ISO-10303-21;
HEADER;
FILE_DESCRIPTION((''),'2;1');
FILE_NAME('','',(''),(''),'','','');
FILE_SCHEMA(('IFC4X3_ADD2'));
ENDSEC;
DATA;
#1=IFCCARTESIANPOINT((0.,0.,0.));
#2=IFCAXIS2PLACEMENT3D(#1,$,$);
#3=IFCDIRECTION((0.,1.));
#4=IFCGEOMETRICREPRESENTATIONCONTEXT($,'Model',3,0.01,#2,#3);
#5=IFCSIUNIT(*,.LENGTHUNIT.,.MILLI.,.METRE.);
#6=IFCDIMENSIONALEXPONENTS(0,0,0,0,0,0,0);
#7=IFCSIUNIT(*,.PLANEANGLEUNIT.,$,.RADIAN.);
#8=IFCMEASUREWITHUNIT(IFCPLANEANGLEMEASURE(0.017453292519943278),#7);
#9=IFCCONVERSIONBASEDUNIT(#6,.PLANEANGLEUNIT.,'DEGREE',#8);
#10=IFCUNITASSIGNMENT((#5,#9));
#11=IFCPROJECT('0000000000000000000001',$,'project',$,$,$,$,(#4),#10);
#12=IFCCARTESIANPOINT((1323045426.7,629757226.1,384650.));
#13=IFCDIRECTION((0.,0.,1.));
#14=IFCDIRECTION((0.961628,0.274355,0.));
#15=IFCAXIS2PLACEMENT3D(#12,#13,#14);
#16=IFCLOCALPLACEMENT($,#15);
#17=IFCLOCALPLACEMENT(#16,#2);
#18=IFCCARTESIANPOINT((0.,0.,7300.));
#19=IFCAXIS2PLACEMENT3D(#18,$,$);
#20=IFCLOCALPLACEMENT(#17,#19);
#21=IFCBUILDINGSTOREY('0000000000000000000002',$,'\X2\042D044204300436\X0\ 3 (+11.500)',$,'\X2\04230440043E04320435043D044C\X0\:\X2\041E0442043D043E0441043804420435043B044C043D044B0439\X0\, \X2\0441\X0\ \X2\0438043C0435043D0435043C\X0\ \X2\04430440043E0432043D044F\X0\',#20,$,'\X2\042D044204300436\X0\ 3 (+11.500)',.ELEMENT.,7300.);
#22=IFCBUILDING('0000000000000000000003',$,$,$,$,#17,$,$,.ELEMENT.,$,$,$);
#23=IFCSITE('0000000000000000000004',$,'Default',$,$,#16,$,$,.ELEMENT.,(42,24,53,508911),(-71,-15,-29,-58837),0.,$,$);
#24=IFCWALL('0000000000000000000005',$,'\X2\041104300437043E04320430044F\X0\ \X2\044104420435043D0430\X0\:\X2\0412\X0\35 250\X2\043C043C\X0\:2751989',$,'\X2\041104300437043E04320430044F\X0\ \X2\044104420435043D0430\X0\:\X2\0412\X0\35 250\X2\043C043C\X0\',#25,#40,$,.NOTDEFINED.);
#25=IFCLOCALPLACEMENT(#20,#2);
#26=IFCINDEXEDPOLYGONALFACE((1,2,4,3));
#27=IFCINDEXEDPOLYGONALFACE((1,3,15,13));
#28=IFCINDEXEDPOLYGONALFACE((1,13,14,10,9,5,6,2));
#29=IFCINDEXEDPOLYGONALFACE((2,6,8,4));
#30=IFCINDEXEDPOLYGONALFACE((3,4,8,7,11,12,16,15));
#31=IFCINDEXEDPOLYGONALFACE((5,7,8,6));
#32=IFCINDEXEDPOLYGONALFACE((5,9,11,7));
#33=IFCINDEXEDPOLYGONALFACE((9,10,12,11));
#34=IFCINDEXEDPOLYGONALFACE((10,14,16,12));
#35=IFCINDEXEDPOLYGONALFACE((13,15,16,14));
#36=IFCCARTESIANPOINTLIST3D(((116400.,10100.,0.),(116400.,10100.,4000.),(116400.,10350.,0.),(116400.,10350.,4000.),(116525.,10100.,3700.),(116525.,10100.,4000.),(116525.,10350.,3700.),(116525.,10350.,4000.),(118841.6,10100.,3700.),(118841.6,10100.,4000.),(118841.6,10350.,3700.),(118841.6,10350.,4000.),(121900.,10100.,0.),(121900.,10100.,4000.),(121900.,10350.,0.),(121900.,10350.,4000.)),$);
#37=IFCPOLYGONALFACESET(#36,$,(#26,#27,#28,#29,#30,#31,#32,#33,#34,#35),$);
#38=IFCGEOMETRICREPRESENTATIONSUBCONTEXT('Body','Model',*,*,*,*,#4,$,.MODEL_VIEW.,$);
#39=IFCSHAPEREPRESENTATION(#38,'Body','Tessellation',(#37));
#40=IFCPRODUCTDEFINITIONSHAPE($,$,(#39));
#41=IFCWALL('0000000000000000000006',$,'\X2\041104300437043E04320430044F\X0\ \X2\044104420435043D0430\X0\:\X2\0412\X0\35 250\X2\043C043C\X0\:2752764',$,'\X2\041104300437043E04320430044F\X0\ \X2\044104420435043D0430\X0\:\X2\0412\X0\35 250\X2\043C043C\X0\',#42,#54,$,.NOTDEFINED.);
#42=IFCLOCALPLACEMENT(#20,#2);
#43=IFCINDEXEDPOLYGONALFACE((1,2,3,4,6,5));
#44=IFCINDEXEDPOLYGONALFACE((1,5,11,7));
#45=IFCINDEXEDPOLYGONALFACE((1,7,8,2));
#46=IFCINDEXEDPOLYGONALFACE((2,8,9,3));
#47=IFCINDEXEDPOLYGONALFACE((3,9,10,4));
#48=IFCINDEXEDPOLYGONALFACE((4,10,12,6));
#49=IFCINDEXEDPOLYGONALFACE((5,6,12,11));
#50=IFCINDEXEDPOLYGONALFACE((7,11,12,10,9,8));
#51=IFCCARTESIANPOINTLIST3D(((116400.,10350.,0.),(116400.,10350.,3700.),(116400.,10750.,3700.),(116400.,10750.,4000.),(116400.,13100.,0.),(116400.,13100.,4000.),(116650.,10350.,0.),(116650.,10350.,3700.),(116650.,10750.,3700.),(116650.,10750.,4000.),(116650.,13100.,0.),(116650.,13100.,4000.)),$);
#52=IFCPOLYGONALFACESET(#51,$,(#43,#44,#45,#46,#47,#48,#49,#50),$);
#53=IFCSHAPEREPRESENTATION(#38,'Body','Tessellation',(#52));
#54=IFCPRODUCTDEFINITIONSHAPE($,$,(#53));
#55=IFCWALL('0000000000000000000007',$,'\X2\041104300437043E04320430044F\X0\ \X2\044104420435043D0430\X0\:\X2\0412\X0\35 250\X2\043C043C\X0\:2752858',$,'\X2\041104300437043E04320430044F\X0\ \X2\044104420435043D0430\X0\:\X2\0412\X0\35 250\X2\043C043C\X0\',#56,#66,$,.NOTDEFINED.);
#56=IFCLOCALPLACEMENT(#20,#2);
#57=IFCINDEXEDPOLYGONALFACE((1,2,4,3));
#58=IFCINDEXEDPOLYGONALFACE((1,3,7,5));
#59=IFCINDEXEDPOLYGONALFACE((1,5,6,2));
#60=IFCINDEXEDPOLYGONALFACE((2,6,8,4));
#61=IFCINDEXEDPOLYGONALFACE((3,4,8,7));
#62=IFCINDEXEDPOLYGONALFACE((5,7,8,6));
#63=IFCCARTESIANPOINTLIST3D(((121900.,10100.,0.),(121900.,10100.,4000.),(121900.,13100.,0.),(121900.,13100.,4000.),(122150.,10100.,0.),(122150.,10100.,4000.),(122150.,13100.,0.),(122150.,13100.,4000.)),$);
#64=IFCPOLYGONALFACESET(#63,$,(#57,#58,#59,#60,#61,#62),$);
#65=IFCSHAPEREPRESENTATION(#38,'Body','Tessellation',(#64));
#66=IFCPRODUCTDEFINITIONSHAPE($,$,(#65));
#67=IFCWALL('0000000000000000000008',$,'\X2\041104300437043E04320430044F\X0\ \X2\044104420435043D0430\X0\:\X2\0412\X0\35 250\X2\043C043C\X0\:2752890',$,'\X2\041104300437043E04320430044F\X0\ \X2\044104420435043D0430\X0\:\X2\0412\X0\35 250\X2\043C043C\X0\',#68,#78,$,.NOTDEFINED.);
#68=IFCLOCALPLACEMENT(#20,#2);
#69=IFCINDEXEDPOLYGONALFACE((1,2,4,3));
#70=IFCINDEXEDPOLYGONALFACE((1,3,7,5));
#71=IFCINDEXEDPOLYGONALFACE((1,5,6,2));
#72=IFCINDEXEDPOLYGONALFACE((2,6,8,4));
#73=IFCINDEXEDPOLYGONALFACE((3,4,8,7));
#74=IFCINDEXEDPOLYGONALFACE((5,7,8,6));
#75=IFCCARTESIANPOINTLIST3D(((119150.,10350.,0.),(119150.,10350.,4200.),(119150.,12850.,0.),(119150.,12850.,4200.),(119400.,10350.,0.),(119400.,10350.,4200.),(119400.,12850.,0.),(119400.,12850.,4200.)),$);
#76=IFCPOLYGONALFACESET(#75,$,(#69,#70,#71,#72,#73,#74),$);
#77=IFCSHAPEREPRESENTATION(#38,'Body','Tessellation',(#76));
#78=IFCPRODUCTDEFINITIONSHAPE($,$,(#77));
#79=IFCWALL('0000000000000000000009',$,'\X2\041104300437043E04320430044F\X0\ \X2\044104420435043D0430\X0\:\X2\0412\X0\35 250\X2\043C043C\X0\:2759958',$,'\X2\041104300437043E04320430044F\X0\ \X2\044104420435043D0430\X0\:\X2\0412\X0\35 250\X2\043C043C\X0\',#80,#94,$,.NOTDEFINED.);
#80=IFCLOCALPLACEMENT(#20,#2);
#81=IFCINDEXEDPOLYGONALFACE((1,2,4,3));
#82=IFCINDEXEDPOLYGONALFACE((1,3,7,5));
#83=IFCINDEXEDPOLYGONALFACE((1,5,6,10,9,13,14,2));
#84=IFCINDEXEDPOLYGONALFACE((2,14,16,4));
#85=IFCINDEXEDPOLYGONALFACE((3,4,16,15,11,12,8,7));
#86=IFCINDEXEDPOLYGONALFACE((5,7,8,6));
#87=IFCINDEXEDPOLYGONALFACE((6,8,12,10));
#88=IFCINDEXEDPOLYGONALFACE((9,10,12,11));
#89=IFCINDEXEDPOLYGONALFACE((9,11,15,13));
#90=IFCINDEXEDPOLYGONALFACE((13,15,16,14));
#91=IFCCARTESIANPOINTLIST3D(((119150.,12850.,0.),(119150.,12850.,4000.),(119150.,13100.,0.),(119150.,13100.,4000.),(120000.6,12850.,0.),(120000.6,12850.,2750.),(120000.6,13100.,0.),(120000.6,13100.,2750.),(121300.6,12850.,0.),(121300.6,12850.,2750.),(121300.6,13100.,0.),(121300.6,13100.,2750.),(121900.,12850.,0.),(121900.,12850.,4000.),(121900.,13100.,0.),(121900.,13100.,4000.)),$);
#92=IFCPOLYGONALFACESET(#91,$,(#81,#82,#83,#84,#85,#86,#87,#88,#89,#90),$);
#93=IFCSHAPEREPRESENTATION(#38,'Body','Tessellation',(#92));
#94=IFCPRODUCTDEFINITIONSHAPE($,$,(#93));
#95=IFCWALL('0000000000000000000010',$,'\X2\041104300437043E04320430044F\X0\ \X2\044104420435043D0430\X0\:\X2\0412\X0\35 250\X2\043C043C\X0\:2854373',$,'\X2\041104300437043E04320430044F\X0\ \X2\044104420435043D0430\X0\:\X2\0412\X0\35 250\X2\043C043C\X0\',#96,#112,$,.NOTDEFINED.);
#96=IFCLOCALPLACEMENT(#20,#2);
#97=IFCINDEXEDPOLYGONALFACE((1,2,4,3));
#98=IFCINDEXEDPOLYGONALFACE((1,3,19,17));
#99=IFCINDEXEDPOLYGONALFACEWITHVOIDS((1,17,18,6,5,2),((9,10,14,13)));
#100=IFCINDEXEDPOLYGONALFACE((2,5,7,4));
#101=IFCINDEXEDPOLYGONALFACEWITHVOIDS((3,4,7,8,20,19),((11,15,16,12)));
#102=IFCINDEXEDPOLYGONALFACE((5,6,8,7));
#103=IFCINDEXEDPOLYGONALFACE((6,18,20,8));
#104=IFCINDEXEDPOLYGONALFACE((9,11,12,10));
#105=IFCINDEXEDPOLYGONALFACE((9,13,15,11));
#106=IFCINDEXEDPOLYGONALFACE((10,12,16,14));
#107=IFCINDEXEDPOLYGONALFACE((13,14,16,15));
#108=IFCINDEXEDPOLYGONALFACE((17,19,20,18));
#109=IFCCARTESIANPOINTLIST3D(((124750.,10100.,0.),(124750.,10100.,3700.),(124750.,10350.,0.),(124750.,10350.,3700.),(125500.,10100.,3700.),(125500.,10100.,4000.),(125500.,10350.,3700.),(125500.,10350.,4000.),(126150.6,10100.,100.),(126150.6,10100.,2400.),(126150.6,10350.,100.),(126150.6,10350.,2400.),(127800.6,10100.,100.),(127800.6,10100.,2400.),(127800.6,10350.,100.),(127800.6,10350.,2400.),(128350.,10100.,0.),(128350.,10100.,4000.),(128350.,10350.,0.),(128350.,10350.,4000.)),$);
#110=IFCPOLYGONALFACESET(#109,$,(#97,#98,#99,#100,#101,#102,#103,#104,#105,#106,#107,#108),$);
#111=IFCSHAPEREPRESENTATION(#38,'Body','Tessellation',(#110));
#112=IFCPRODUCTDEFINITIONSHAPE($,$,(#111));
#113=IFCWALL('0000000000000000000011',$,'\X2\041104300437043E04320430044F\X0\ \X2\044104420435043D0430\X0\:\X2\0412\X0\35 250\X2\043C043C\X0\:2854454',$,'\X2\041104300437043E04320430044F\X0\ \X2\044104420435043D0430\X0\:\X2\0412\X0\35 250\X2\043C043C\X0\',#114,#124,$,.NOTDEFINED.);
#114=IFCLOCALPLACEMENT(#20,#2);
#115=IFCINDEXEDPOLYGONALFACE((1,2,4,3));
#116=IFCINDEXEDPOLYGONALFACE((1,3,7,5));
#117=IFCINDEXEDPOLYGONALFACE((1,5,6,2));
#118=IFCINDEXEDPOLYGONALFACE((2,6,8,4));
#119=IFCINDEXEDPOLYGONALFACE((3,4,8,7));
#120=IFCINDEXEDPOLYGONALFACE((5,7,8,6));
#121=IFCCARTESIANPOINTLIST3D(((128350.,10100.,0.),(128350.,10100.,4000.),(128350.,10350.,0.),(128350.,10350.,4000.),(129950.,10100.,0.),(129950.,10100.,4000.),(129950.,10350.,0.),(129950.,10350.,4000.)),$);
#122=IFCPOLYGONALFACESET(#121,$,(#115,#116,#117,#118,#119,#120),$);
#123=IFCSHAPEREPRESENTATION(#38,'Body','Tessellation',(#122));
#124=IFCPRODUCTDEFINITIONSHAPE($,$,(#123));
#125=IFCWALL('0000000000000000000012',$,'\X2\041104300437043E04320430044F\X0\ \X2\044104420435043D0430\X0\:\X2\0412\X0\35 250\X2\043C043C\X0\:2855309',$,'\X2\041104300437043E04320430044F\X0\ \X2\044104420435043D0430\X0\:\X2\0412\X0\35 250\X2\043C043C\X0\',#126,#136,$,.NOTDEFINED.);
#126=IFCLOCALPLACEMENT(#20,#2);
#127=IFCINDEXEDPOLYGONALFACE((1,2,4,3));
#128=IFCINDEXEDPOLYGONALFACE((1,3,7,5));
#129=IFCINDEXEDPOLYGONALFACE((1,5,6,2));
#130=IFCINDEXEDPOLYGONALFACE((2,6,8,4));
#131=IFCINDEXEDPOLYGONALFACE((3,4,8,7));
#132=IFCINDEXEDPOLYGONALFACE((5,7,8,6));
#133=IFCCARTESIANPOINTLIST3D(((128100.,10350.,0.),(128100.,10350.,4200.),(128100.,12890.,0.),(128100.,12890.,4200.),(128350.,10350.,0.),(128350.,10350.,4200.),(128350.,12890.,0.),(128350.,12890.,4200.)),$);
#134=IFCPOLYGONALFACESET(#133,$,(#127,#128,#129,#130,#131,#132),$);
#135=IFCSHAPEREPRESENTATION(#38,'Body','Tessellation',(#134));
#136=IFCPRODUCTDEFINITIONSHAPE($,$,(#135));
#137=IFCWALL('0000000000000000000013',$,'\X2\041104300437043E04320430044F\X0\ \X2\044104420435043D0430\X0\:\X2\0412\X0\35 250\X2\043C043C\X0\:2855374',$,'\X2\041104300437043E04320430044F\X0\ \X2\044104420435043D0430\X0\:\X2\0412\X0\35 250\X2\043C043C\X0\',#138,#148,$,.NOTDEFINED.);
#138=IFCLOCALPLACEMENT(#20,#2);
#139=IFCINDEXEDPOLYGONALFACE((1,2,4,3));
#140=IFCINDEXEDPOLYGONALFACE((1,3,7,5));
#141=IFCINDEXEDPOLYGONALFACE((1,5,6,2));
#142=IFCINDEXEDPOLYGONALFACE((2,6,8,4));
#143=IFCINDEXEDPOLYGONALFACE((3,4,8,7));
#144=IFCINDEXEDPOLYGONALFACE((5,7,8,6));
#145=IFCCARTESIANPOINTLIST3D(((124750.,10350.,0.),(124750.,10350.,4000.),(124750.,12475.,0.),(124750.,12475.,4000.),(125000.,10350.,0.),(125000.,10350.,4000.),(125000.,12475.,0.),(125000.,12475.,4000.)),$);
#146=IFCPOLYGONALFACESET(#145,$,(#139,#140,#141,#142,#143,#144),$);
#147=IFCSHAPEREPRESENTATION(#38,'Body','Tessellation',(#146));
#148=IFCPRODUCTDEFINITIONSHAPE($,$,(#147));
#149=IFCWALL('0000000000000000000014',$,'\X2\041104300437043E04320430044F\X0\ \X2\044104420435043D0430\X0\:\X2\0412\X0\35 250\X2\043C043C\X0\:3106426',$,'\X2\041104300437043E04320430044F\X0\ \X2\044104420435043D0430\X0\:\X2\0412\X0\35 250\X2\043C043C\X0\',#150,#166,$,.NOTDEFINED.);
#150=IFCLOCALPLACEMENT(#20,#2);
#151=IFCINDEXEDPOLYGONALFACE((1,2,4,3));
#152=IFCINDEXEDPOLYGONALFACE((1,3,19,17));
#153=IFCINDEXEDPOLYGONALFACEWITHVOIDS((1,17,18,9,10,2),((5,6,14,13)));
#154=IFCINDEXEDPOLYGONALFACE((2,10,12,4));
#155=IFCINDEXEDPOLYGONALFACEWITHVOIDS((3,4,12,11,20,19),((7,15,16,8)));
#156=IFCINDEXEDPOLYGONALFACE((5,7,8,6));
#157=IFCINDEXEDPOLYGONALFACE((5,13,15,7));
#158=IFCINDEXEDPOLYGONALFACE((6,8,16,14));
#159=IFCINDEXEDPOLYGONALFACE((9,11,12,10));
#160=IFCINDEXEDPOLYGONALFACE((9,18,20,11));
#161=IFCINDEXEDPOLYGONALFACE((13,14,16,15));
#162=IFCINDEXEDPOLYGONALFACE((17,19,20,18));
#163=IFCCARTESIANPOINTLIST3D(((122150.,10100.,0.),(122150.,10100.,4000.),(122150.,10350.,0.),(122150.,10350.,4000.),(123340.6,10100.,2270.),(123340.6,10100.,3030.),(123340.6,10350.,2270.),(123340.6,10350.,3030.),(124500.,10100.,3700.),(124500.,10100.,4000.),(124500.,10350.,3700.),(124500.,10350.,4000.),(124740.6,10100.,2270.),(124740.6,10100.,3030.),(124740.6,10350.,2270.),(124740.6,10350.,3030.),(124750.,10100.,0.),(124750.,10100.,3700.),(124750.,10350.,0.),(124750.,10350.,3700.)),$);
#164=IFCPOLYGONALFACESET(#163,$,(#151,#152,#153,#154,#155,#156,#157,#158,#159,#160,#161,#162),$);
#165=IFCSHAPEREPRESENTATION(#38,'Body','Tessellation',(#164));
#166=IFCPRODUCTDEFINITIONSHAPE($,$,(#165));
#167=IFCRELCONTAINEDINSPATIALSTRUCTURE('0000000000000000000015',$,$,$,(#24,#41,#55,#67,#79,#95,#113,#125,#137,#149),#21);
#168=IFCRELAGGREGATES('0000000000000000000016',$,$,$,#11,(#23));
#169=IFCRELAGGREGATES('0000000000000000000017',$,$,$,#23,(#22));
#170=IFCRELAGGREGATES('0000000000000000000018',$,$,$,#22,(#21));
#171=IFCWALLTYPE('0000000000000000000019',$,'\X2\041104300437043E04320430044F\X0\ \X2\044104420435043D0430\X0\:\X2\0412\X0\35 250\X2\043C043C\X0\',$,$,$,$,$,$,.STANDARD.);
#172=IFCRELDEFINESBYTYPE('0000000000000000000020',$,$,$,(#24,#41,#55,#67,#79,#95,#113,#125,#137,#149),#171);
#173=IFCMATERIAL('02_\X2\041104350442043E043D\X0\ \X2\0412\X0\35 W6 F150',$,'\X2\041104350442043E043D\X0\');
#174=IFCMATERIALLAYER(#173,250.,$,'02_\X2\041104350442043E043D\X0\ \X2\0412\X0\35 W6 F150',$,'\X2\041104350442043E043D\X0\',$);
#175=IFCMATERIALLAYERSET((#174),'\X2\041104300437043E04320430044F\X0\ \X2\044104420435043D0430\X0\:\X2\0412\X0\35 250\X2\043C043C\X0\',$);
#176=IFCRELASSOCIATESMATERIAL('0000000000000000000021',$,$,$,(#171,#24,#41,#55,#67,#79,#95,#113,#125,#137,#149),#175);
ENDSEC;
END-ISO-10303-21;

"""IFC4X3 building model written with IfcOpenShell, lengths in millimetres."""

from ifc_helpers import new_model, entity, si_unit, converted_unit, direction, frame, frame_2d, origin, origin_2d_with_axis, place, context, subcontext, project, spatial, rectangle, extrude, material, layer, layer_set, type_object, element, save


model = new_model("IFC4X3")

# Units and contexts
model_context = context("Model", 3, precision=0.01, world=origin(), true_north=direction((0.0, 1.0)))
body_context = subcontext(model_context, "Body", "Model", "MODEL_VIEW")
ifc_project = project(units=[si_unit("LENGTHUNIT", "METRE", prefix="MILLI"), converted_unit("PLANEANGLEUNIT", "DEGREE", entity("IfcPlaneAngleMeasure", 0.017453292519943278), si_unit("PLANEANGLEUNIT", "RADIAN"), dimensions=[0, 0, 0, 0, 0, 0, 0])], contexts=[model_context])

# Site, building, storey
site_placement = place(None, frame((1323045426.7, 629757226.1, 384650.0), z_axis=(0.0, 0.0, 1.0), x_axis=(0.961628, 0.274355, 0.0)))
site = spatial("IfcSite", under=ifc_project, at=site_placement, Name="Default", CompositionType="ELEMENT", RefLatitude=(42, 24, 53, 508911), RefLongitude=(-71, -15, -29, -58837), RefElevation=0.0)
building_placement = place(site_placement, origin())
building = spatial("IfcBuilding", under=site, at=building_placement, CompositionType="ELEMENT")
storey_placement = place(building_placement, frame((0.0, 0.0, 7300.0)))
storey = spatial("IfcBuildingStorey", under=building, at=storey_placement, Name="Этаж 3 (+11.500)", ObjectType="Уровень:Относительный, с именем уровня", LongName="Этаж 3 (+11.500)", CompositionType="ELEMENT", Elevation=7300.0)

# Wall, opening
ifc_material = material(Name="02_Бетон В35 W6 F150", Category="Бетон")
ifc_layer_1 = layer(ifc_material, 250.0, Name="02_Бетон В35 W6 F150", Category="Бетон")
ifc_layer_set_1 = layer_set([ifc_layer_1], Name="Базовая стена:В35 250мм")
wall_type_1 = type_object("IfcWallType", Name="Базовая стена:В35 250мм", PredefinedType="STANDARD", material=ifc_layer_set_1)
wall_1_placement = place(storey_placement, frame((116400.0, 10225.0, 0.0)))
wall_1 = element("IfcWall", 1, at=wall_1_placement, inside=storey, type_object=wall_type_1, material=ifc_layer_set_1, Name="Базовая стена:В35 250мм:2751989", ObjectType="Базовая стена:В35 250мм", PredefinedType="NOTDEFINED", context=body_context, shape_type="SweptSolid", body=[
    extrude(rectangle(XDim=5500.0, YDim=250.0, at=frame_2d((2750.0, 0.0), x_axis=(-1.0, 0.0))), origin(), (0.0, 0.0, 1.0), 4000.0),
])
opening_1_placement = place(wall_1_placement, origin())
element("IfcOpeningElement", 2, at=opening_1_placement, cuts=wall_1, PredefinedType="OPENING", context=body_context, shape_type="SweptSolid", body=[
    extrude(rectangle(XDim=300.0, YDim=2316.6, at=frame_2d((0.0, 0.0), x_axis=(0.0, 1.0))), frame((1283.3, 125.0, 3850.0), z_axis=(0.0, -1.0, 0.0), x_axis=(-1.0, 0.0, 0.0)), (0.0, 0.0, 1.0), 250.0),
])

# Wall, opening
wall_2_placement = place(storey_placement, frame((116525.0, 10350.0, 0.0), z_axis=(0.0, 0.0, 1.0), x_axis=(0.0, 1.0, 0.0)))
wall_2 = element("IfcWall", 3, at=wall_2_placement, inside=storey, type_object=wall_type_1, material=ifc_layer_set_1, Name="Базовая стена:В35 250мм:2752764", ObjectType="Базовая стена:В35 250мм", PredefinedType="NOTDEFINED", context=body_context, shape_type="SweptSolid", body=[
    extrude(rectangle(XDim=2750.0, YDim=250.0, at=frame_2d((1375.0, 0.0), x_axis=(-1.0, 0.0))), origin(), (0.0, 0.0, 1.0), 4000.0),
])
opening_2_placement = place(wall_2_placement, origin())
element("IfcOpeningElement", 4, at=opening_2_placement, cuts=wall_2, PredefinedType="OPENING", context=body_context, shape_type="SweptSolid", body=[
    extrude(rectangle(XDim=300.0, YDim=525.0, at=frame_2d((0.0, 0.0), x_axis=(0.0, 1.0))), frame((137.5, 125.0, 3850.0), z_axis=(0.0, -1.0, 0.0), x_axis=(-1.0, 0.0, 0.0)), (0.0, 0.0, 1.0), 250.0),
])

# Walls
wall_3_placement = place(storey_placement, frame((122025.0, 13100.0, 0.0), z_axis=(0.0, 0.0, 1.0), x_axis=(0.0, -1.0, 0.0)))
element("IfcWall", 5, at=wall_3_placement, inside=storey, type_object=wall_type_1, material=ifc_layer_set_1, Name="Базовая стена:В35 250мм:2752858", ObjectType="Базовая стена:В35 250мм", PredefinedType="NOTDEFINED", context=body_context, shape_type="SweptSolid", body=[
    extrude(rectangle(XDim=3000.0, YDim=250.0, at=frame_2d((1500.0, 0.0), x_axis=(-1.0, 0.0))), origin(), (0.0, 0.0, 1.0), 4000.0),
])
wall_4_placement = place(storey_placement, frame((119275.0, 12850.0, 0.0), z_axis=(0.0, 0.0, 1.0), x_axis=(0.0, -1.0, 0.0)))
element("IfcWall", 6, at=wall_4_placement, inside=storey, type_object=wall_type_1, material=ifc_layer_set_1, Name="Базовая стена:В35 250мм:2752890", ObjectType="Базовая стена:В35 250мм", PredefinedType="NOTDEFINED", context=body_context, shape_type="SweptSolid", body=[
    extrude(rectangle(XDim=2500.0, YDim=250.0, at=frame_2d((1250.0, 0.0), x_axis=(-1.0, 0.0))), origin(), (0.0, 0.0, 1.0), 4200.0),
])

# Wall, opening
wall_5_placement = place(storey_placement, frame((119150.0, 12975.0, 0.0)))
wall_5 = element("IfcWall", 7, at=wall_5_placement, inside=storey, type_object=wall_type_1, material=ifc_layer_set_1, Name="Базовая стена:В35 250мм:2759958", ObjectType="Базовая стена:В35 250мм", PredefinedType="NOTDEFINED", context=body_context, shape_type="SweptSolid", body=[
    extrude(rectangle(XDim=2750.0, YDim=250.0, at=frame_2d((1375.0, 0.0), x_axis=(1.0, 0.0))), origin(), (0.0, 0.0, 1.0), 4000.0),
])
opening_3_placement = place(wall_5_placement, frame((-119150.0, -12975.0, 0.0)))
element("IfcOpeningElement", 8, at=opening_3_placement, cuts=wall_5, PredefinedType="OPENING", context=body_context, shape_type="SweptSolid", body=[
    extrude(rectangle(XDim=2750.0, YDim=1300.0, at=frame_2d((0.0, 0.0), x_axis=(1.0, 0.0))), frame((120650.6, 11326.0, 1375.0), z_axis=(0.0, 1.0, 0.0), x_axis=(0.0, 0.0, -1.0)), (0.0, 0.0, 1.0), 3048.0),
])

# Wall, openings
wall_6_placement = place(storey_placement, frame((124750.0, 10225.0, 0.0)))
wall_6 = element("IfcWall", 9, at=wall_6_placement, inside=storey, type_object=wall_type_1, material=ifc_layer_set_1, Name="Базовая стена:В35 250мм:2854373", ObjectType="Базовая стена:В35 250мм", PredefinedType="NOTDEFINED", context=body_context, shape_type="SweptSolid", body=[
    extrude(rectangle(XDim=3600.0, YDim=250.0, at=frame_2d((1800.0, 0.0), x_axis=(-1.0, 0.0))), origin(), (0.0, 0.0, 1.0), 4000.0),
])
opening_4_placement = place(wall_6_placement, origin())
element("IfcOpeningElement", 10, at=opening_4_placement, cuts=wall_6, PredefinedType="OPENING", context=body_context, shape_type="SweptSolid", body=[
    extrude(rectangle(XDim=300.0, YDim=750.0, at=frame_2d((0.0, 0.0), x_axis=(0.0, 1.0))), frame((375.0, 125.0, 3850.0), z_axis=(0.0, -1.0, 0.0), x_axis=(-1.0, 0.0, 0.0)), (0.0, 0.0, 1.0), 250.0),
])
opening_5_placement = place(wall_6_placement, frame((-124750.0, -10225.0, 100.0)))
element("IfcOpeningElement", 11, at=opening_5_placement, cuts=wall_6, PredefinedType="OPENING", context=body_context, shape_type="SweptSolid", body=[
    extrude(rectangle(XDim=2300.0, YDim=1650.0, at=frame_2d((0.0, 0.0), x_axis=(0.0, 1.0))), frame((126975.6, 8826.0, 1150.0), z_axis=(0.0, 1.0, 0.0), x_axis=(1.0, 0.0, 0.0)), (0.0, 0.0, 1.0), 3048.0),
])

# Walls
wall_7_placement = place(storey_placement, frame((128350.0, 10225.0, 0.0)))
element("IfcWall", 12, at=wall_7_placement, inside=storey, type_object=wall_type_1, material=ifc_layer_set_1, Name="Базовая стена:В35 250мм:2854454", ObjectType="Базовая стена:В35 250мм", PredefinedType="NOTDEFINED", context=body_context, shape_type="SweptSolid", body=[
    extrude(rectangle(XDim=1600.0, YDim=250.0, at=frame_2d((800.0, 0.0), x_axis=(-1.0, 0.0))), origin(), (0.0, 0.0, 1.0), 4000.0),
])
wall_8_placement = place(storey_placement, frame((128225.0, 12890.0, 0.0), z_axis=(0.0, 0.0, 1.0), x_axis=(0.0, -1.0, 0.0)))
element("IfcWall", 13, at=wall_8_placement, inside=storey, type_object=wall_type_1, material=ifc_layer_set_1, Name="Базовая стена:В35 250мм:2855309", ObjectType="Базовая стена:В35 250мм", PredefinedType="NOTDEFINED", context=body_context, shape_type="SweptSolid", body=[
    extrude(rectangle(XDim=2540.0, YDim=250.0, at=frame_2d((1270.0, 0.0), x_axis=(-1.0, 0.0))), origin(), (0.0, 0.0, 1.0), 4200.0),
])
wall_9_placement = place(storey_placement, frame((124875.0, 12475.0, 0.0), z_axis=(0.0, 0.0, 1.0), x_axis=(0.0, -1.0, 0.0)))
element("IfcWall", 14, at=wall_9_placement, inside=storey, type_object=wall_type_1, material=ifc_layer_set_1, Name="Базовая стена:В35 250мм:2855374", ObjectType="Базовая стена:В35 250мм", PredefinedType="NOTDEFINED", context=body_context, shape_type="SweptSolid", body=[
    extrude(rectangle(XDim=2125.0, YDim=250.0, at=frame_2d((1062.5, 0.0), x_axis=(-1.0, 0.0))), origin(), (0.0, 0.0, 1.0), 4000.0),
])

# Wall, openings
wall_10_placement = place(storey_placement, frame((122150.0, 10225.0, 0.0)))
wall_10 = element("IfcWall", 15, at=wall_10_placement, inside=storey, type_object=wall_type_1, material=ifc_layer_set_1, Name="Базовая стена:В35 250мм:3106426", ObjectType="Базовая стена:В35 250мм", PredefinedType="NOTDEFINED", context=body_context, shape_type="SweptSolid", body=[
    extrude(rectangle(XDim=2600.0, YDim=250.0, at=frame_2d((1300.0, 0.0), x_axis=(-1.0, 0.0))), origin(), (0.0, 0.0, 1.0), 4000.0),
])
opening_6_placement = place(wall_10_placement, origin())
element("IfcOpeningElement", 16, at=opening_6_placement, cuts=wall_10, PredefinedType="OPENING", context=body_context, shape_type="SweptSolid", body=[
    extrude(rectangle(XDim=300.0, YDim=250.0, at=origin_2d_with_axis()), frame((2475.0, 125.0, 3850.0), z_axis=(0.0, -1.0, 0.0), x_axis=(0.0, 0.0, 1.0)), (0.0, 0.0, 1.0), 250.0),
])
opening_7_placement = place(wall_10_placement, frame((-122150.0, -10225.0, 2270.0)))
element("IfcOpeningElement", 17, at=opening_7_placement, cuts=wall_10, PredefinedType="OPENING", context=body_context, shape_type="SweptSolid", body=[
    extrude(rectangle(XDim=760.0, YDim=1400.0, at=frame_2d((0.0, 0.0), x_axis=(0.0, 1.0))), frame((124040.6, 8576.0, 380.0), z_axis=(0.0, 1.0, 0.0), x_axis=(1.0, 0.0, 0.0)), (0.0, 0.0, 1.0), 3048.0),
])

save(model, "model.ifc")
